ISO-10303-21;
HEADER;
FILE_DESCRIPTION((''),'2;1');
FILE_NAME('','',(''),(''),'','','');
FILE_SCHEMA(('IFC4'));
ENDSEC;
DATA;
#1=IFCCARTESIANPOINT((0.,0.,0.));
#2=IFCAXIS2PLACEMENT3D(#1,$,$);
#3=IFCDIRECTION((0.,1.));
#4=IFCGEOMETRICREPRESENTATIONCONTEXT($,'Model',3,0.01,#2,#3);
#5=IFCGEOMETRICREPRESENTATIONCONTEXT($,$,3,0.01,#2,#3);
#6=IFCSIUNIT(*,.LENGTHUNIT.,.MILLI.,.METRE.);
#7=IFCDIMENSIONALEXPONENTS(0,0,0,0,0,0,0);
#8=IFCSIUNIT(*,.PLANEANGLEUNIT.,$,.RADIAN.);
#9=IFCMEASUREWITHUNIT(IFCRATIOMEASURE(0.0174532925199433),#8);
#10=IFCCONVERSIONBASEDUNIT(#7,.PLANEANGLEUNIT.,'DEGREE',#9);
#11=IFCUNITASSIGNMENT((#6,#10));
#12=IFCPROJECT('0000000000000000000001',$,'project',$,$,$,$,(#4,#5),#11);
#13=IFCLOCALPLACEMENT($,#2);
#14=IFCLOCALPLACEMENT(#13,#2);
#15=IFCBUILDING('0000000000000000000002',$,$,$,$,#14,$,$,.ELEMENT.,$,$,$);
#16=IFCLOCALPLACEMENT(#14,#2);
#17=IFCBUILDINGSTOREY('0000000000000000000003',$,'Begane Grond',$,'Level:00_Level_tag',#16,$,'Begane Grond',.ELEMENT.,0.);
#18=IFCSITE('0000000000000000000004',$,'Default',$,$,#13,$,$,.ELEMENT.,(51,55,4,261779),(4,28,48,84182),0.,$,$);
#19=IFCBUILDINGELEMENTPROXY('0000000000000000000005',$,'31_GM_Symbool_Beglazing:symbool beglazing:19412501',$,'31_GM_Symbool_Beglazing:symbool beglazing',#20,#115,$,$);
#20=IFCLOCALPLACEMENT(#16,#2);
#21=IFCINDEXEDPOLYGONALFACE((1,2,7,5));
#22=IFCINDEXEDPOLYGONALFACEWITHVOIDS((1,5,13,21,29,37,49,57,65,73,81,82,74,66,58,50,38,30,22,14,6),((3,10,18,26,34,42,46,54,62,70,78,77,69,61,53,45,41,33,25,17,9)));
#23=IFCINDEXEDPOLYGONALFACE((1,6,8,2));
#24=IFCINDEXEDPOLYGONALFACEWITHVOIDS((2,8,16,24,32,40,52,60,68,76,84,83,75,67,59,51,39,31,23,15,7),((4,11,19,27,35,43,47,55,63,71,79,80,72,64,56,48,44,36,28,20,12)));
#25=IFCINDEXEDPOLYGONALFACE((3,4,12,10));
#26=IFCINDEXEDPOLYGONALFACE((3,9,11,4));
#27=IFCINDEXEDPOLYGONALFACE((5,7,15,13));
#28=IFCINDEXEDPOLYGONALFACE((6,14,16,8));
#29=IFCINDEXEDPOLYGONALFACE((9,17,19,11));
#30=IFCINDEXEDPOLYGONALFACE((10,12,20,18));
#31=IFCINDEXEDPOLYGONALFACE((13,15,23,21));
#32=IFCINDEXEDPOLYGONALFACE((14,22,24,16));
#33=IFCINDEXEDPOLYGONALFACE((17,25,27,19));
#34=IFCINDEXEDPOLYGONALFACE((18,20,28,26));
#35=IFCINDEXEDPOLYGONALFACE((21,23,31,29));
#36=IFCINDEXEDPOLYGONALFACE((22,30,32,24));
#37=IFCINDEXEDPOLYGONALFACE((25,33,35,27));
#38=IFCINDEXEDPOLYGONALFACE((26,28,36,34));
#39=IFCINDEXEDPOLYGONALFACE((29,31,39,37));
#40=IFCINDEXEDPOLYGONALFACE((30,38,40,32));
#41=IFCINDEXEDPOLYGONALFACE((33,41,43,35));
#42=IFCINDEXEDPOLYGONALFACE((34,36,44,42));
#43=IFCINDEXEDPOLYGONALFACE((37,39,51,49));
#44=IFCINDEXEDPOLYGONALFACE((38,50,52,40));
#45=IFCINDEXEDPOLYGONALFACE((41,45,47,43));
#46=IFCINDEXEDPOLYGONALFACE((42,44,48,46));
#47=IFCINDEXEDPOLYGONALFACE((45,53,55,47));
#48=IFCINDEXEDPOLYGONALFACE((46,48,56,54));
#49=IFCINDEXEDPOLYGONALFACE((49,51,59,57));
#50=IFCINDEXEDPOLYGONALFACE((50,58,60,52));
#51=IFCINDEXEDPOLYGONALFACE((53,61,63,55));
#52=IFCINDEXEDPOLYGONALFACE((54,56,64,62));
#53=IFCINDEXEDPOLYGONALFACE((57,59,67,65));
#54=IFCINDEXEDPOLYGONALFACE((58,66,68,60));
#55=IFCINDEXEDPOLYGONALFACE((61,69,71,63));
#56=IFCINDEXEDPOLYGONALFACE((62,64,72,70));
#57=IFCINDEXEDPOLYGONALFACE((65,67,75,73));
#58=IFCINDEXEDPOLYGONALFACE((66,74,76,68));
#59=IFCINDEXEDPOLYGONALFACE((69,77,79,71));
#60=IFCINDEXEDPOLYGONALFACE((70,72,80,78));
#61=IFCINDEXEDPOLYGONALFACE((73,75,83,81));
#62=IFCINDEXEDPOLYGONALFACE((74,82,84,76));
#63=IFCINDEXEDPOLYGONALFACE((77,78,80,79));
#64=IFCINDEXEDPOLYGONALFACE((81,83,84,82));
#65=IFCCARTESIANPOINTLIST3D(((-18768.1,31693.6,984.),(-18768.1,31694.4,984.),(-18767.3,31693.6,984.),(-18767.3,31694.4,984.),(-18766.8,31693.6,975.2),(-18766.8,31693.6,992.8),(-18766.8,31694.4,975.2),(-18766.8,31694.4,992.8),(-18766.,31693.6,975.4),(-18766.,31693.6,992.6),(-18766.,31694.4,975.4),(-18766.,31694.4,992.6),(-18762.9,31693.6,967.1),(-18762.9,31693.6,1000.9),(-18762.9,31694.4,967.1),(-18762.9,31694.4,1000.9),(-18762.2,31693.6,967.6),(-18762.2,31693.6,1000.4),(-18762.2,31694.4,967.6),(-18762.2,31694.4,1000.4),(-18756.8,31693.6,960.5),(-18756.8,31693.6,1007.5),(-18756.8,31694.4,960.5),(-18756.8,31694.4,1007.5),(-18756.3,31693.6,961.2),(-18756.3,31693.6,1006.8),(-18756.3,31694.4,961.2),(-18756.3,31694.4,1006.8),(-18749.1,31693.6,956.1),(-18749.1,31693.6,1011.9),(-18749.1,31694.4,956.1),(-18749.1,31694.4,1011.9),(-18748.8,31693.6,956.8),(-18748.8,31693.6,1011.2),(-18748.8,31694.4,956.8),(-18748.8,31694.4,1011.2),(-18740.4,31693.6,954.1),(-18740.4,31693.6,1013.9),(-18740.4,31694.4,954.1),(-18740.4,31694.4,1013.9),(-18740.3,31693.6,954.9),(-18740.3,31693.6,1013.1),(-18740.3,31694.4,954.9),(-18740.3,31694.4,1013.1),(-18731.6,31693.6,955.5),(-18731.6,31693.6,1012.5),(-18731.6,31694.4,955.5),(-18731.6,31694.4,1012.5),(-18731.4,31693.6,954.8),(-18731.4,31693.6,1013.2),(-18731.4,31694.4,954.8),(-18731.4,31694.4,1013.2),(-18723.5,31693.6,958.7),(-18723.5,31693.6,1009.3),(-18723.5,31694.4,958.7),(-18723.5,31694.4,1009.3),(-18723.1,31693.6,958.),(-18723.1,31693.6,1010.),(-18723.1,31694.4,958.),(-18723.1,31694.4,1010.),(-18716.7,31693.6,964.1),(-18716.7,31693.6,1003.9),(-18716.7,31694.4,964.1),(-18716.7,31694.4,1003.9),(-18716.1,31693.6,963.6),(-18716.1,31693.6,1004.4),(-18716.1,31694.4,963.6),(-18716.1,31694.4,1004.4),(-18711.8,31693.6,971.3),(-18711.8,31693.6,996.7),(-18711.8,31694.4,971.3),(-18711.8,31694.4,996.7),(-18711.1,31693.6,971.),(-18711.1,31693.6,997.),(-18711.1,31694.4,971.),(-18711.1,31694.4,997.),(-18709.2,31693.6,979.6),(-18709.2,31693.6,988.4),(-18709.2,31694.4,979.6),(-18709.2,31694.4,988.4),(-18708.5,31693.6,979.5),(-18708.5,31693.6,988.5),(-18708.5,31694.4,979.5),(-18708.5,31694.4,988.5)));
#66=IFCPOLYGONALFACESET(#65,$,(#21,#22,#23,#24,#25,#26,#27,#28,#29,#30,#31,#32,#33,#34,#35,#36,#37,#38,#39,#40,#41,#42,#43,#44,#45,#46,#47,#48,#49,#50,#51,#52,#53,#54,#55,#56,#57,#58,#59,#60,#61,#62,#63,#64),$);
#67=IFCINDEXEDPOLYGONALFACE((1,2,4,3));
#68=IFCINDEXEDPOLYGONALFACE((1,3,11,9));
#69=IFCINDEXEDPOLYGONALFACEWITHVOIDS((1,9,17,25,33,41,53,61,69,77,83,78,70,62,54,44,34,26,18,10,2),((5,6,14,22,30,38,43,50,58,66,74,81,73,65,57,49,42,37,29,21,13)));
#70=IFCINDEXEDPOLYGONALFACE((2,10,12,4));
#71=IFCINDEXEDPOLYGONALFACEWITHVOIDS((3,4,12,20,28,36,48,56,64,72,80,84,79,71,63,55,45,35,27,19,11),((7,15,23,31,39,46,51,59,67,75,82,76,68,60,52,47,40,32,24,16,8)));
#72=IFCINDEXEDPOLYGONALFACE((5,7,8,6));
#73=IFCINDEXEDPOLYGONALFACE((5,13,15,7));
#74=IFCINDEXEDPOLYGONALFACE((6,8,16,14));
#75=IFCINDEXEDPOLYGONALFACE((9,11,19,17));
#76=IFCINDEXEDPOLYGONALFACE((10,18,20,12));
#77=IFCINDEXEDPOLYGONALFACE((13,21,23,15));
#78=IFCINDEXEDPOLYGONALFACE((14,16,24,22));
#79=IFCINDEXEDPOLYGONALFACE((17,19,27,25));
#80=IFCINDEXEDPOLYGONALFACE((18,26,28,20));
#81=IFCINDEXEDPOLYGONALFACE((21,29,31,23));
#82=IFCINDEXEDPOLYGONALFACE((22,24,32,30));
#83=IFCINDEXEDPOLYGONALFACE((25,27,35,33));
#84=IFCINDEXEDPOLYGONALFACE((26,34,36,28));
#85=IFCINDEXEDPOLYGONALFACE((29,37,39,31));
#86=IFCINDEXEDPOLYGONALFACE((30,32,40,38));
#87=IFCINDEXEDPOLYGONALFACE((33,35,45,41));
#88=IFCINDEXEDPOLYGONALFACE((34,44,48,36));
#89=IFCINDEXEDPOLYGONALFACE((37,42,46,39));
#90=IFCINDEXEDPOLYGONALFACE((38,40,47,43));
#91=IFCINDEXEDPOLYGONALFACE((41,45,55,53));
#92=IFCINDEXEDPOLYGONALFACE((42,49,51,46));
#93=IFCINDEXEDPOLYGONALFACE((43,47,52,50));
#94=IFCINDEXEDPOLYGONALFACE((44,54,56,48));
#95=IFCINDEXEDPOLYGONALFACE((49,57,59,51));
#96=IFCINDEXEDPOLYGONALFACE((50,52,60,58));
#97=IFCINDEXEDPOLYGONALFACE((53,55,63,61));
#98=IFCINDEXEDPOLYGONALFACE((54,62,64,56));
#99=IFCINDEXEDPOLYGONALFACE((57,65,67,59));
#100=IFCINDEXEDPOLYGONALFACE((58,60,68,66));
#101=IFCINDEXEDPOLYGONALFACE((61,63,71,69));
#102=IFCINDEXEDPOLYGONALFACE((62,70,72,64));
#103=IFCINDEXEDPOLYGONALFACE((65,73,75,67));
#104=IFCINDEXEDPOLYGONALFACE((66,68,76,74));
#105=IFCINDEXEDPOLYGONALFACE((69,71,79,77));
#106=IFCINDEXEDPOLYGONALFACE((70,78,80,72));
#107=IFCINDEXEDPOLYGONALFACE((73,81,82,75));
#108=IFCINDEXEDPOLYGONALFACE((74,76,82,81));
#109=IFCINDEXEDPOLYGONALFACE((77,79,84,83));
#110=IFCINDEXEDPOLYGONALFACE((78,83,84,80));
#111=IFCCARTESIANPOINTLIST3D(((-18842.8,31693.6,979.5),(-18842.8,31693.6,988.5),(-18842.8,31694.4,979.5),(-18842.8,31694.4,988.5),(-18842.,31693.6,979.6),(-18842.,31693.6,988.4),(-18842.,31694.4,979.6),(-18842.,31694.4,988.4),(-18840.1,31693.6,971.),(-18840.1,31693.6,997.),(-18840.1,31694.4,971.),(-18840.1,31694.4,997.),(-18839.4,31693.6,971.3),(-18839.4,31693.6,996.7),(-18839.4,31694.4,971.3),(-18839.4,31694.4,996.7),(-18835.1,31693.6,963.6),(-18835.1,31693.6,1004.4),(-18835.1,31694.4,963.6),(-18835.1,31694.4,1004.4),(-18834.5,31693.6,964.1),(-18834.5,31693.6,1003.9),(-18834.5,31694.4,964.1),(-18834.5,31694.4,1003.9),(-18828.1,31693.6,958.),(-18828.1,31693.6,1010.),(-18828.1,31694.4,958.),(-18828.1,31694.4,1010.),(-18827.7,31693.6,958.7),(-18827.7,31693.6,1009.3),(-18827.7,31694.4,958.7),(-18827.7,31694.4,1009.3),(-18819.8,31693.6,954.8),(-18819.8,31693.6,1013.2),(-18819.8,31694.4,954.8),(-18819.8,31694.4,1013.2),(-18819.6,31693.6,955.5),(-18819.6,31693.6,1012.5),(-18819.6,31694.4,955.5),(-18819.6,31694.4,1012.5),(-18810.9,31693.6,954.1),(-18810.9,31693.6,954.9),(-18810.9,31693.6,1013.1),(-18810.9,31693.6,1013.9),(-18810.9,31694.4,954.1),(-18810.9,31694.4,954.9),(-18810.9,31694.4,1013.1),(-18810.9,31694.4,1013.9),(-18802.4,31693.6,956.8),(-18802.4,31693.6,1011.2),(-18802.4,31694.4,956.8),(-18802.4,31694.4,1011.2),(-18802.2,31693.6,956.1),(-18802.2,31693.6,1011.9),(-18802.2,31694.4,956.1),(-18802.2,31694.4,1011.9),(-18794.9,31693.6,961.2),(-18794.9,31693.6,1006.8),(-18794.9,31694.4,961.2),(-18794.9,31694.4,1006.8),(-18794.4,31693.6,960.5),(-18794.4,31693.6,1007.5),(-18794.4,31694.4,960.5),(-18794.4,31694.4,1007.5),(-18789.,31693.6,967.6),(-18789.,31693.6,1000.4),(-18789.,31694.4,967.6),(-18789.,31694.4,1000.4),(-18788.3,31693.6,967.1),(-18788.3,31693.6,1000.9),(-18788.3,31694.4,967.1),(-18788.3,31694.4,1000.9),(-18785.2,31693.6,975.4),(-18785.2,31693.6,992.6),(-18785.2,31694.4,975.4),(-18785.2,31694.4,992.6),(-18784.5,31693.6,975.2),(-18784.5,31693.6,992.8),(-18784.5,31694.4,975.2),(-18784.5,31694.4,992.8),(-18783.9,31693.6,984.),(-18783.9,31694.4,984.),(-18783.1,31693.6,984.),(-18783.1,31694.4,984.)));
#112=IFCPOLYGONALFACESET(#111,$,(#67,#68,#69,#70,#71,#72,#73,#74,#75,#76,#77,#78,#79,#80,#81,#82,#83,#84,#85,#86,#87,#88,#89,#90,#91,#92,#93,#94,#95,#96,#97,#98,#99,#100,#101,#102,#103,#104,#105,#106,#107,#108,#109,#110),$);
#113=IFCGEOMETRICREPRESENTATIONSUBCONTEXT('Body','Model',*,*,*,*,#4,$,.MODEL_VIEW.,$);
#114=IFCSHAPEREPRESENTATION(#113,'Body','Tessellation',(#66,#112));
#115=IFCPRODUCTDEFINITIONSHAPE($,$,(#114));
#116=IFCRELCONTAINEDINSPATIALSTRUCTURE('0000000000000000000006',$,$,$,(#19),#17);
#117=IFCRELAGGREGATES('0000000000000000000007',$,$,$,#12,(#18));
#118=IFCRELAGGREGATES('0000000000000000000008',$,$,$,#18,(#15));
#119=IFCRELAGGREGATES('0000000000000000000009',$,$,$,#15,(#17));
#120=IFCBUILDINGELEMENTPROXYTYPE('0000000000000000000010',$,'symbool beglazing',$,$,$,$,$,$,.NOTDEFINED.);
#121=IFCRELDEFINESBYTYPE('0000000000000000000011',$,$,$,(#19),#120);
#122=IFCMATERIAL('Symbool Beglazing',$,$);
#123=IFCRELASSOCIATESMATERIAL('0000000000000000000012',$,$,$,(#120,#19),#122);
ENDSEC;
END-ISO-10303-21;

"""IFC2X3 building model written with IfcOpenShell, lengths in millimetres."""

from ifc_helpers import new_model, entity, si_unit, converted_unit, direction, frame, frame_2d, origin, place, context, subcontext, project, spatial, hollow_circle, extrude, source, transform, mapped, material, type_object, type_shapes, element, save


model = new_model("IFC2X3")

# Units and contexts
model_context = context("Model", 3, precision=0.01, world=origin(), true_north=direction((0.0, 1.0)))
context_of_model = context(None, 3, precision=0.01, world=origin(), true_north=direction((0.0, 1.0)))
body_context = subcontext(model_context, "Body", "Model", "MODEL_VIEW")
ifc_project = project(units=[si_unit("LENGTHUNIT", "METRE", prefix="MILLI"), converted_unit("PLANEANGLEUNIT", "DEGREE", entity("IfcRatioMeasure", 0.0174532925199433), si_unit("PLANEANGLEUNIT", "RADIAN"), dimensions=[0, 0, 0, 0, 0, 0, 0])], contexts=[model_context, context_of_model])

# Site, building, storey
site_placement = place(None, origin())
site = spatial("IfcSite", under=ifc_project, at=site_placement, Name="Default", CompositionType="ELEMENT", RefLatitude=(51, 55, 4, 261779), RefLongitude=(4, 28, 48, 84182), RefElevation=0.0)
building_placement = place(site_placement, origin())
building = spatial("IfcBuilding", under=site, at=building_placement, CompositionType="ELEMENT")
storey_placement = place(building_placement, origin())
storey = spatial("IfcBuildingStorey", under=building, at=storey_placement, Name="Begane Grond", ObjectType="Level:00_Level_tag", LongName="Begane Grond", CompositionType="ELEMENT", Elevation=0.0)

# Building element proxy
ifc_material_1 = material(Name="Symbool Beglazing")
building_element_proxy_type_1 = type_object("IfcBuildingElementProxyType", Name="symbool beglazing", PredefinedType="NOTDEFINED", material=ifc_material_1)
shared_shape_1 = source(origin(), body_context, "Body", "SweptSolid", [
    extrude(hollow_circle(Radius=30.0, WallThickness=0.8, at=frame_2d((0.0, 0.0), x_axis=(1.0, 0.0))), frame((37.5, 0.0, 0.0), z_axis=(0.0, 0.0, 1.0), x_axis=(-1.0, 0.0, 0.0)), (0.0, 0.0, 1.0), 0.8),
    extrude(hollow_circle(Radius=30.0, WallThickness=0.8, at=frame_2d((0.0, 0.0), x_axis=(1.0, 0.0))), frame((-37.5, 0.0, 0.0)), (0.0, 0.0, 1.0), 0.8),
])
type_shapes(building_element_proxy_type_1, [shared_shape_1])
for number, where, z_axis, x_axis, name in (
    (1, (-18775.6, 31694.4, 984.0), (0.0, -1.0, 0.0), (1.0, 0.0, 0.0), "31_GM_Symbool_Beglazing:symbool beglazing:19412501"),
):
    element("IfcBuildingElementProxy", number, at=place(storey_placement, frame(where, z_axis=z_axis, x_axis=x_axis)), inside=storey, type_object=building_element_proxy_type_1, material=ifc_material_1, Name=name, ObjectType="31_GM_Symbool_Beglazing:symbool beglazing", context=body_context, shape_type="MappedRepresentation", body=[
        mapped(shared_shape_1, transform((0.0, 0.0, 0.0), scale=1.0)),
    ])

save(model, "model.ifc")
